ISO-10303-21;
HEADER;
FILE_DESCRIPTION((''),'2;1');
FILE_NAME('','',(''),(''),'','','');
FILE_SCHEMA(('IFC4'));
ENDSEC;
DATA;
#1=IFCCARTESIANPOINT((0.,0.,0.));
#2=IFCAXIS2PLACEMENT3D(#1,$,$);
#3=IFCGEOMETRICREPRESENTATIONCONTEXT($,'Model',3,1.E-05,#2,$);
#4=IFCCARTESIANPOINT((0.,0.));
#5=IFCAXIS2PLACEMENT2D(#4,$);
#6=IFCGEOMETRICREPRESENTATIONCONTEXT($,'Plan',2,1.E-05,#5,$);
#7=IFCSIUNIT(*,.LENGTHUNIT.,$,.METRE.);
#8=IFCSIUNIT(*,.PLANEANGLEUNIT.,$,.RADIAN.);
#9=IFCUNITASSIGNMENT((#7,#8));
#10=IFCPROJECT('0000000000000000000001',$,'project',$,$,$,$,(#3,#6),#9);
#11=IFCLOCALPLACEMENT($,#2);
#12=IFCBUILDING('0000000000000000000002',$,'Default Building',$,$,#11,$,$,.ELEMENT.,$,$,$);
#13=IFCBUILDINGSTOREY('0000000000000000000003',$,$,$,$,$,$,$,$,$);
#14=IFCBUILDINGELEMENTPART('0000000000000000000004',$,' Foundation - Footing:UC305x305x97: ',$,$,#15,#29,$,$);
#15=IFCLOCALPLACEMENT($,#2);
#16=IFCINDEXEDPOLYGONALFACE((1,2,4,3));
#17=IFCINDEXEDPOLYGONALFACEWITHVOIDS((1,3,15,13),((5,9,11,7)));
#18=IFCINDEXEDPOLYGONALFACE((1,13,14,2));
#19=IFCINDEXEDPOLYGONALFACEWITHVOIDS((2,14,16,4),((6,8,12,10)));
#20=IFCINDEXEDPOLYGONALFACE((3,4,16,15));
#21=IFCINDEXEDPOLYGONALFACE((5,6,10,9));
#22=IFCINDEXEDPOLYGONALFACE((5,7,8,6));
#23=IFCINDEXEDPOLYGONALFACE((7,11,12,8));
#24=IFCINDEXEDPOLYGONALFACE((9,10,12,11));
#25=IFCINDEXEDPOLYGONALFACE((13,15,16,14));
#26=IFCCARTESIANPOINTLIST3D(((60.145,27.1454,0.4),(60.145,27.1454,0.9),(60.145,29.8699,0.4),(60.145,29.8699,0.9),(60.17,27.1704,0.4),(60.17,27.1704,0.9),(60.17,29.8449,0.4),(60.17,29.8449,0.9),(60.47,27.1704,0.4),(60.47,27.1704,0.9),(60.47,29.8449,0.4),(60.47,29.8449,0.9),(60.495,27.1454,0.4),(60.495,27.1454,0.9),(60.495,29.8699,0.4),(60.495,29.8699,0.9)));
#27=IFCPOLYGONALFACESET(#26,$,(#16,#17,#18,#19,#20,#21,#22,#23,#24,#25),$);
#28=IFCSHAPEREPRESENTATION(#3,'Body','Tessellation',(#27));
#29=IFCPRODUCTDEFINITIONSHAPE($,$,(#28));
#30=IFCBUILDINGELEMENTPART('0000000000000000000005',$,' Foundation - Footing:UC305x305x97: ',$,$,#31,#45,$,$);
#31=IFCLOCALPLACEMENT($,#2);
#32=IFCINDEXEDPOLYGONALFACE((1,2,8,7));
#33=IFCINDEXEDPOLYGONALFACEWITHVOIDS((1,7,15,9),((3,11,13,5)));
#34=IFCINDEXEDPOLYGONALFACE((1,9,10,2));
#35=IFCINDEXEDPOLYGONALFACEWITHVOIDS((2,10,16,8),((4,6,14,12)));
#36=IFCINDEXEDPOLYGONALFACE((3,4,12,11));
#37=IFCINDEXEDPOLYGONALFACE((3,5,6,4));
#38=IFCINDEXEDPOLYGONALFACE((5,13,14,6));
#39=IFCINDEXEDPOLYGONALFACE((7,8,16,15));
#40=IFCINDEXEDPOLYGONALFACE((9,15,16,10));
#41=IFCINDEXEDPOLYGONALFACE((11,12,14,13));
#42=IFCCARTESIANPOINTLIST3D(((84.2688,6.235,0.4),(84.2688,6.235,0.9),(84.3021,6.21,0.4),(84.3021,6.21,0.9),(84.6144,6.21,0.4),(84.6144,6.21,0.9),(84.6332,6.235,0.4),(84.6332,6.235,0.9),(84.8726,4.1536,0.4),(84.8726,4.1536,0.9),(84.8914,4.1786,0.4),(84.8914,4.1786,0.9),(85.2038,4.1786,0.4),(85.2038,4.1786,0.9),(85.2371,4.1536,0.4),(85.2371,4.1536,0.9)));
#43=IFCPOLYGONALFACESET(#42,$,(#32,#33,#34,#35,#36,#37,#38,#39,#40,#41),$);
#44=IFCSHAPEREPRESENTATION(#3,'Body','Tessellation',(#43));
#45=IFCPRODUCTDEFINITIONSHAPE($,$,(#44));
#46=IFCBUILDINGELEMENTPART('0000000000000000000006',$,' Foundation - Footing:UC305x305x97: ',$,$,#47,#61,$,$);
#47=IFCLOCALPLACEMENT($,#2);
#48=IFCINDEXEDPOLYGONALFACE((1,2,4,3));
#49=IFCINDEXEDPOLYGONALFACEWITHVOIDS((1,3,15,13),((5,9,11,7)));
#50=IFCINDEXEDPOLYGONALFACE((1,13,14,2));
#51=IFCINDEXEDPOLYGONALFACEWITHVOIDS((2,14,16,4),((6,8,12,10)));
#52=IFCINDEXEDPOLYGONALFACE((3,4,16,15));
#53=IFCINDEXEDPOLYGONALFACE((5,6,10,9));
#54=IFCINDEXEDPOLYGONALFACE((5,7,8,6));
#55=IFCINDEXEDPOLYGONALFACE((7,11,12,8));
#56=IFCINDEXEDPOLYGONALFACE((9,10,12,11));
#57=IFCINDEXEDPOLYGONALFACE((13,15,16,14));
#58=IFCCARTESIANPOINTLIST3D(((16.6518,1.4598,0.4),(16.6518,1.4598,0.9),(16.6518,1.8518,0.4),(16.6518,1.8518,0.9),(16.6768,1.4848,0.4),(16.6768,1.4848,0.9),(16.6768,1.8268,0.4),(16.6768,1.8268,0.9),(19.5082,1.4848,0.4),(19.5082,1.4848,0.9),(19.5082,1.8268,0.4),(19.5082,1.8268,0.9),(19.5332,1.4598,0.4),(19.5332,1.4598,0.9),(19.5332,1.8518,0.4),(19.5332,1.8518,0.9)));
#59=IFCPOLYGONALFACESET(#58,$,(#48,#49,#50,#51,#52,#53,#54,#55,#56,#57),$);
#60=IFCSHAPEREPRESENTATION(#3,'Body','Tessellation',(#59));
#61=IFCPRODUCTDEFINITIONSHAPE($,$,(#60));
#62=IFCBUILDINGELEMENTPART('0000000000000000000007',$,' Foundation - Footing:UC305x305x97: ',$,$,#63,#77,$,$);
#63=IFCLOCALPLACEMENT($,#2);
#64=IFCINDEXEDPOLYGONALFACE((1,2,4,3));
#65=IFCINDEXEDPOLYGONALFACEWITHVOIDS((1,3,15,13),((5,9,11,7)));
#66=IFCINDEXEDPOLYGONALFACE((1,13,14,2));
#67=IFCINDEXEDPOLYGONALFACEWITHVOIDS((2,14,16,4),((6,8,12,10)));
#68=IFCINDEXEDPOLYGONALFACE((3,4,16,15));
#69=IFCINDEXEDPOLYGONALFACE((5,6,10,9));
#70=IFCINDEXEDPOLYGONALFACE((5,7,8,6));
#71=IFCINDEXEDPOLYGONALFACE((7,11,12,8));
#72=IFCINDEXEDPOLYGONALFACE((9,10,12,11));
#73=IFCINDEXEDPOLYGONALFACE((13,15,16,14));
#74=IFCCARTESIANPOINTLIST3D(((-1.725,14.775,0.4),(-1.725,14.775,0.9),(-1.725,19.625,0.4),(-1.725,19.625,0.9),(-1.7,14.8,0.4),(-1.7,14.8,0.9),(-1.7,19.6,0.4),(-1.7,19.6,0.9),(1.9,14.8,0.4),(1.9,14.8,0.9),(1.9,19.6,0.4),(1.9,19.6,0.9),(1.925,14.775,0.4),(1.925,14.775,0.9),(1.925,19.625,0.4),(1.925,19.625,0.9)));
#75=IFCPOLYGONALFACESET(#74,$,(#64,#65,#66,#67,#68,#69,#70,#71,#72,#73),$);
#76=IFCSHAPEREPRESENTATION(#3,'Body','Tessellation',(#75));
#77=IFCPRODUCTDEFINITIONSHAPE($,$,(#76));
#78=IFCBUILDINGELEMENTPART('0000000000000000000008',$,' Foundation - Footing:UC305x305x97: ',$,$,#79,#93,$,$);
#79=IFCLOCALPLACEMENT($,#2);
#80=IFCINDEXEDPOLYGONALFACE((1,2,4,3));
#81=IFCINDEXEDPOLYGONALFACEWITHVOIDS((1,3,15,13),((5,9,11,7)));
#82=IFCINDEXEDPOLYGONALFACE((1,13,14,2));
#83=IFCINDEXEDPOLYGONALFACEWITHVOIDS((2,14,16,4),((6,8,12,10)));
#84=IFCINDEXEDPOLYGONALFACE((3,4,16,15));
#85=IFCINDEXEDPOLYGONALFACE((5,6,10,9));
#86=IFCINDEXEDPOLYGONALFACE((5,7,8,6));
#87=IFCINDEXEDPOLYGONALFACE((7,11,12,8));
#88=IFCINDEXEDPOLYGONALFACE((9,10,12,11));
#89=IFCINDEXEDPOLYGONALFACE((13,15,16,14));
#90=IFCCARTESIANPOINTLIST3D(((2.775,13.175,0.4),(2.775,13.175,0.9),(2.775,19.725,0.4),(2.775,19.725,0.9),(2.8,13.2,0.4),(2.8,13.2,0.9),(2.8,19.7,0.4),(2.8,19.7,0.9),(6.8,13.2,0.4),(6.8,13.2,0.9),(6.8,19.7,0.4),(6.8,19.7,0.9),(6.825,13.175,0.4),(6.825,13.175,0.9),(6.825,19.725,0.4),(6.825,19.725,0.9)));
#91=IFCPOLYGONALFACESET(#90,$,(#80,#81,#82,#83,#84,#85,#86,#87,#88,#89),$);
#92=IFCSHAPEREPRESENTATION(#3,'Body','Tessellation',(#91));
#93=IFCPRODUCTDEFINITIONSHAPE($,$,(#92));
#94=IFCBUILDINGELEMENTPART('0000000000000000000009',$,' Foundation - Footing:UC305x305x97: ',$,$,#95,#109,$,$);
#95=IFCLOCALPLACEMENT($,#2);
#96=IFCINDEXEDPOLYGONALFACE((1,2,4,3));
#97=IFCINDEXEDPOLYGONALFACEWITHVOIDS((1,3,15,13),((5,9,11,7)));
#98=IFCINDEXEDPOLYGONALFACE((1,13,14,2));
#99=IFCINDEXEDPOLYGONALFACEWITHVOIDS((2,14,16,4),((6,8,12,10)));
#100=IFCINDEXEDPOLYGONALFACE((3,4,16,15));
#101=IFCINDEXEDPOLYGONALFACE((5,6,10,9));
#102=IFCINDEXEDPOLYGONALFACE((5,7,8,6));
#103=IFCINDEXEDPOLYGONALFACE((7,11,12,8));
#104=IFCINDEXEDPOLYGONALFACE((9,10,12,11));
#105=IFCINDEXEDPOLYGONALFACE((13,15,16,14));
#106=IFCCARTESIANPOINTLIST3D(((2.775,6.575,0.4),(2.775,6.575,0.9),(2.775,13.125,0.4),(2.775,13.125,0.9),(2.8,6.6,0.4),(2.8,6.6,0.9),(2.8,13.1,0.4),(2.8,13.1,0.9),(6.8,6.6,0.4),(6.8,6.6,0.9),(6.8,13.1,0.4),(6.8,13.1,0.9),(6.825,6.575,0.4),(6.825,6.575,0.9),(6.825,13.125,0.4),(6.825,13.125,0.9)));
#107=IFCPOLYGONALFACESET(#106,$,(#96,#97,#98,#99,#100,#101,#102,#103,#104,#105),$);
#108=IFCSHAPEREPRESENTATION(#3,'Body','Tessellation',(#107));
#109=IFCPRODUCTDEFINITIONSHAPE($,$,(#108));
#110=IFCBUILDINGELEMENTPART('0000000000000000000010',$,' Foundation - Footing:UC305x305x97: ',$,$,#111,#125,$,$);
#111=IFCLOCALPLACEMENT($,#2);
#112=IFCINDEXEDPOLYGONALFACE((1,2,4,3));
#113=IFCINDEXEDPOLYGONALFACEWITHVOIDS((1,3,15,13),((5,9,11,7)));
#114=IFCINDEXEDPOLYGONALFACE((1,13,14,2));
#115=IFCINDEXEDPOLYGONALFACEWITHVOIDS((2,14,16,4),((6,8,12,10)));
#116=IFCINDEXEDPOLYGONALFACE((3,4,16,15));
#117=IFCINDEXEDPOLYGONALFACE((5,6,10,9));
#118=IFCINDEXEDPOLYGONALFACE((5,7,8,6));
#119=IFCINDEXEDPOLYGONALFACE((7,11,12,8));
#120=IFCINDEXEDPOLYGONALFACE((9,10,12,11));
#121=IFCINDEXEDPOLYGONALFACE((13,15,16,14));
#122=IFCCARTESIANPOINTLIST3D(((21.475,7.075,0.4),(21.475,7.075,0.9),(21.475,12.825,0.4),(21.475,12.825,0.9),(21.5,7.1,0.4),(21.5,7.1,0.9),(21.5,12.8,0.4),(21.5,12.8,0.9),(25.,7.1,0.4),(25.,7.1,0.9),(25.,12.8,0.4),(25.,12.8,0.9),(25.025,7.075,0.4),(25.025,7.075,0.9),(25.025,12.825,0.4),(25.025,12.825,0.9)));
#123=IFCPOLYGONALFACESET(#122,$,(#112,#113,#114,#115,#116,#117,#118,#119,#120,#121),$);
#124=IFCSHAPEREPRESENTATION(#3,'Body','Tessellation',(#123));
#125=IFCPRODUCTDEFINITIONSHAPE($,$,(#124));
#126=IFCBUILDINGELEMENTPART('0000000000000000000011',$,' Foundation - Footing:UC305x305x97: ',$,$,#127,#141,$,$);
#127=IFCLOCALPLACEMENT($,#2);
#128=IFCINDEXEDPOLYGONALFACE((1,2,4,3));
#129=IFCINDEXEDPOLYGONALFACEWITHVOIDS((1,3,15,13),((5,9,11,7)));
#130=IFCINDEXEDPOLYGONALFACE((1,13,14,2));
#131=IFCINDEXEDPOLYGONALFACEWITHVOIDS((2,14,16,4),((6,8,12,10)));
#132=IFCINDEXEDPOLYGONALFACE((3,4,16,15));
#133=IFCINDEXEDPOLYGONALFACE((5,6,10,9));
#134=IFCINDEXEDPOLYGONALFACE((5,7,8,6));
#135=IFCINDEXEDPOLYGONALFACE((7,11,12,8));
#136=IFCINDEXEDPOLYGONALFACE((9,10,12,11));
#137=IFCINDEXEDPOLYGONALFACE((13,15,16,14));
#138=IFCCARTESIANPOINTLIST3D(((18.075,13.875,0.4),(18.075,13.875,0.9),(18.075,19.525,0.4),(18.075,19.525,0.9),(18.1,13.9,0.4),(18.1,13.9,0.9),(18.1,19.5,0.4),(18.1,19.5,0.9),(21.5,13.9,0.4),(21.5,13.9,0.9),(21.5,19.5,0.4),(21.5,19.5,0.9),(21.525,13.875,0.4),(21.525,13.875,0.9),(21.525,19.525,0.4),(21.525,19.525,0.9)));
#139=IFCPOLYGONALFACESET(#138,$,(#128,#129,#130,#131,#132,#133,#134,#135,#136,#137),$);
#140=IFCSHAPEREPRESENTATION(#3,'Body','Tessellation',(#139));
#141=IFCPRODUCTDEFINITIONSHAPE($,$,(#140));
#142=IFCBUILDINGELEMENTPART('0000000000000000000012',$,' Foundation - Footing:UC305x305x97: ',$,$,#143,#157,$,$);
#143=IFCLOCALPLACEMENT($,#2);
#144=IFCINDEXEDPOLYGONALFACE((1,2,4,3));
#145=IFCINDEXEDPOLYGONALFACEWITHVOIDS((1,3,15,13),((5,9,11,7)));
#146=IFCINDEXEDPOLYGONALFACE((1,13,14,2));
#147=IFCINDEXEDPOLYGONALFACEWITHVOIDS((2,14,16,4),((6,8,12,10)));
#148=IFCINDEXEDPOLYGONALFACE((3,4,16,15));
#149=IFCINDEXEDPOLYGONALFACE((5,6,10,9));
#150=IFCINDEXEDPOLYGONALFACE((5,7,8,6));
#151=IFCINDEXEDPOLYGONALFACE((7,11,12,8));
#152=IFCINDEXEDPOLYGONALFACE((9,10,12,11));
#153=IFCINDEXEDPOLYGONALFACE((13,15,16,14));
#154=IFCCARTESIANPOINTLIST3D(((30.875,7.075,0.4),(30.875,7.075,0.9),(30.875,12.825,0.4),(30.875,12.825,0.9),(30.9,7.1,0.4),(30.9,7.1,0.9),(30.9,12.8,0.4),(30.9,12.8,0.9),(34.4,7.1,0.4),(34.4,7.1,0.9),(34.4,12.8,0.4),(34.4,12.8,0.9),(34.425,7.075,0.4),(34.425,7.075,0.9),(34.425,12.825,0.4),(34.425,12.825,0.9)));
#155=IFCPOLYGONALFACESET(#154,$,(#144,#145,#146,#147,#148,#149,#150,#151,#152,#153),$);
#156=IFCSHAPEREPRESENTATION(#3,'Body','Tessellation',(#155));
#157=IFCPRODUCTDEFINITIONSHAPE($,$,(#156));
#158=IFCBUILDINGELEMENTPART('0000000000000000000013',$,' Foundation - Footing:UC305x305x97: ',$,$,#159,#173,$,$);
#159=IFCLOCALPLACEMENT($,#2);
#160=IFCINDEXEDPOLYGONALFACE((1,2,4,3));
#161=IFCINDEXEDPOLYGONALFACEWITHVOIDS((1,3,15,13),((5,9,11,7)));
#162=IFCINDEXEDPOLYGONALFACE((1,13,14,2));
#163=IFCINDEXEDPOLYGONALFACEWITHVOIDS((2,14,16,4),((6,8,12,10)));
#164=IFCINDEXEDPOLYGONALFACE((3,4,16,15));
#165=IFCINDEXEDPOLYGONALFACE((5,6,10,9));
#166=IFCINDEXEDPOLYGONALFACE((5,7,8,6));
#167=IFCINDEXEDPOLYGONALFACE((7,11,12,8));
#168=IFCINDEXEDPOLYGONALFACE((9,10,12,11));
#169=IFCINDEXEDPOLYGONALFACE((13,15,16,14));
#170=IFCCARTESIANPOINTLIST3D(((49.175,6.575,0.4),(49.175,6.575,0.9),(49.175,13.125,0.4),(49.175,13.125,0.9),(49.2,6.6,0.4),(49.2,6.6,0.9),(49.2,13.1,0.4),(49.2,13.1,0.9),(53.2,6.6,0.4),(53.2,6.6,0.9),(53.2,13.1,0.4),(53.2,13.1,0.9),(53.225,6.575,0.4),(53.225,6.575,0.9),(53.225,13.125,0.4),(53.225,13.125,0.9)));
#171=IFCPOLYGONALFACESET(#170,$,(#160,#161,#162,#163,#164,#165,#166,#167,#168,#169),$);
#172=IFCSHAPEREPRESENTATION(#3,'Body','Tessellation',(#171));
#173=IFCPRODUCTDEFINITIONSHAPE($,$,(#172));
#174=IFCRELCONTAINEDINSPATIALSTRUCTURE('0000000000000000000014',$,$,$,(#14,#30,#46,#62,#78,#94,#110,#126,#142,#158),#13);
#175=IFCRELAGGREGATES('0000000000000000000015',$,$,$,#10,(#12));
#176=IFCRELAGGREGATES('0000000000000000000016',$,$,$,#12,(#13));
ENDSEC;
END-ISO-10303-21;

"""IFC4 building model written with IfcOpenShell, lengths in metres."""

from ifc_helpers import new_model, si_unit, origin, origin_2d, place, context, project, spatial, polyline, outline, extrude, element, save


model = new_model("IFC4")

# Units and contexts
model_context = context("Model", 3, precision=1e-05, world=origin())
plan_context = context("Plan", 2, precision=1e-05, world=origin_2d())
ifc_project = project(units=[si_unit("LENGTHUNIT", "METRE"), si_unit("PLANEANGLEUNIT", "RADIAN")], contexts=[model_context, plan_context])

# Building, storey
building_placement = place(None, origin())
building = spatial("IfcBuilding", under=ifc_project, at=building_placement, Name="Default Building", CompositionType="ELEMENT")
storey = spatial("IfcBuildingStorey", under=building)

# Building element parts, openings
building_element_part_1 = element("IfcBuildingElementPart", 1, inside=storey, Name=" Foundation - Footing:UC305x305x97: ", context=model_context, shape_type="SweptSolid", body=[
    extrude(outline(polyline([(60.495, 27.1454, 0.4), (60.145, 27.1454, 0.4), (60.145, 29.8699, 0.4), (60.495, 29.8699, 0.4), (60.495, 27.1454, 0.4)])), None, (0.0, 0.0, 1.0), 0.5),
])
element("IfcOpeningElement", 2, inside=storey, cuts=building_element_part_1, context=model_context, shape_type="SweptSolid", body=[
    extrude(outline(polyline([(60.47, 27.1704, 0.4), (60.17, 27.1704, 0.4), (60.17, 29.8449, 0.4), (60.47, 29.8449, 0.4), (60.47, 27.1704, 0.4)])), None, (0.0, 0.0, 1.0), 0.5),
])
building_element_part_2 = element("IfcBuildingElementPart", 3, inside=storey, Name=" Foundation - Footing:UC305x305x97: ", context=model_context, shape_type="SweptSolid", body=[
    extrude(outline(polyline([(84.8726, 4.1536, 0.4), (85.2371, 4.1536, 0.4), (84.6332, 6.235, 0.4), (84.2688, 6.235, 0.4), (84.8726, 4.1536, 0.4)])), None, (0.0, 0.0, 1.0), 0.5),
])
element("IfcOpeningElement", 4, inside=storey, cuts=building_element_part_2, context=model_context, shape_type="SweptSolid", body=[
    extrude(outline(polyline([(84.8914, 4.1786, 0.4), (85.2038, 4.1786, 0.4), (84.6144, 6.21, 0.4), (84.3021, 6.21, 0.4), (84.8914, 4.1786, 0.4)])), None, (0.0, 0.0, 1.0), 0.5),
])
building_element_part_3 = element("IfcBuildingElementPart", 5, inside=storey, Name=" Foundation - Footing:UC305x305x97: ", context=model_context, shape_type="SweptSolid", body=[
    extrude(outline(polyline([(16.6518, 1.4598, 0.4), (19.5332, 1.4598, 0.4), (19.5332, 1.8518, 0.4), (16.6518, 1.8518, 0.4), (16.6518, 1.4598, 0.4)])), None, (0.0, 0.0, 1.0), 0.5),
])
element("IfcOpeningElement", 6, inside=storey, cuts=building_element_part_3, context=model_context, shape_type="SweptSolid", body=[
    extrude(outline(polyline([(16.6768, 1.4848, 0.4), (19.5082, 1.4848, 0.4), (19.5082, 1.8268, 0.4), (16.6768, 1.8268, 0.4), (16.6768, 1.4848, 0.4)])), None, (0.0, 0.0, 1.0), 0.5),
])
building_element_part_4 = element("IfcBuildingElementPart", 7, inside=storey, Name=" Foundation - Footing:UC305x305x97: ", context=model_context, shape_type="SweptSolid", body=[
    extrude(outline(polyline([(1.925, 19.625, 0.4), (-1.725, 19.625, 0.4), (-1.725, 14.775, 0.4), (1.925, 14.775, 0.4), (1.925, 19.625, 0.4)])), None, (0.0, 0.0, 1.0), 0.5),
])
element("IfcOpeningElement", 8, inside=storey, cuts=building_element_part_4, context=model_context, shape_type="SweptSolid", body=[
    extrude(outline(polyline([(1.9, 19.6, 0.4), (-1.7, 19.6, 0.4), (-1.7, 14.8, 0.4), (1.9, 14.8, 0.4), (1.9, 19.6, 0.4)])), None, (0.0, 0.0, 1.0), 0.5),
])
building_element_part_5 = element("IfcBuildingElementPart", 9, inside=storey, Name=" Foundation - Footing:UC305x305x97: ", context=model_context, shape_type="SweptSolid", body=[
    extrude(outline(polyline([(6.825, 19.725, 0.4), (2.775, 19.725, 0.4), (2.775, 13.175, 0.4), (6.825, 13.175, 0.4), (6.825, 19.725, 0.4)])), None, (0.0, 0.0, 1.0), 0.5),
])
element("IfcOpeningElement", 10, inside=storey, cuts=building_element_part_5, context=model_context, shape_type="SweptSolid", body=[
    extrude(outline(polyline([(6.8, 19.7, 0.4), (2.8, 19.7, 0.4), (2.8, 13.2, 0.4), (6.8, 13.2, 0.4), (6.8, 19.7, 0.4)])), None, (0.0, 0.0, 1.0), 0.5),
])
building_element_part_6 = element("IfcBuildingElementPart", 11, inside=storey, Name=" Foundation - Footing:UC305x305x97: ", context=model_context, shape_type="SweptSolid", body=[
    extrude(outline(polyline([(6.825, 13.125, 0.4), (2.775, 13.125, 0.4), (2.775, 6.575, 0.4), (6.825, 6.575, 0.4), (6.825, 13.125, 0.4)])), None, (0.0, 0.0, 1.0), 0.5),
])
element("IfcOpeningElement", 12, inside=storey, cuts=building_element_part_6, context=model_context, shape_type="SweptSolid", body=[
    extrude(outline(polyline([(6.8, 13.1, 0.4), (2.8, 13.1, 0.4), (2.8, 6.6, 0.4), (6.8, 6.6, 0.4), (6.8, 13.1, 0.4)])), None, (0.0, 0.0, 1.0), 0.5),
])
building_element_part_7 = element("IfcBuildingElementPart", 13, inside=storey, Name=" Foundation - Footing:UC305x305x97: ", context=model_context, shape_type="SweptSolid", body=[
    extrude(outline(polyline([(25.025, 12.825, 0.4), (21.475, 12.825, 0.4), (21.475, 7.075, 0.4), (25.025, 7.075, 0.4), (25.025, 12.825, 0.4)])), None, (0.0, 0.0, 1.0), 0.5),
])
element("IfcOpeningElement", 14, inside=storey, cuts=building_element_part_7, context=model_context, shape_type="SweptSolid", body=[
    extrude(outline(polyline([(25.0, 12.8, 0.4), (21.5, 12.8, 0.4), (21.5, 7.1, 0.4), (25.0, 7.1, 0.4), (25.0, 12.8, 0.4)])), None, (0.0, 0.0, 1.0), 0.5),
])
building_element_part_8 = element("IfcBuildingElementPart", 15, inside=storey, Name=" Foundation - Footing:UC305x305x97: ", context=model_context, shape_type="SweptSolid", body=[
    extrude(outline(polyline([(21.525, 19.525, 0.4), (18.075, 19.525, 0.4), (18.075, 13.875, 0.4), (21.525, 13.875, 0.4), (21.525, 19.525, 0.4)])), None, (0.0, 0.0, 1.0), 0.5),
])
element("IfcOpeningElement", 16, inside=storey, cuts=building_element_part_8, context=model_context, shape_type="SweptSolid", body=[
    extrude(outline(polyline([(21.5, 19.5, 0.4), (18.1, 19.5, 0.4), (18.1, 13.9, 0.4), (21.5, 13.9, 0.4), (21.5, 19.5, 0.4)])), None, (0.0, 0.0, 1.0), 0.5),
])
building_element_part_9 = element("IfcBuildingElementPart", 17, inside=storey, Name=" Foundation - Footing:UC305x305x97: ", context=model_context, shape_type="SweptSolid", body=[
    extrude(outline(polyline([(34.425, 12.825, 0.4), (30.875, 12.825, 0.4), (30.875, 7.075, 0.4), (34.425, 7.075, 0.4), (34.425, 12.825, 0.4)])), None, (0.0, 0.0, 1.0), 0.5),
])
element("IfcOpeningElement", 18, inside=storey, cuts=building_element_part_9, context=model_context, shape_type="SweptSolid", body=[
    extrude(outline(polyline([(34.4, 12.8, 0.4), (30.9, 12.8, 0.4), (30.9, 7.1, 0.4), (34.4, 7.1, 0.4), (34.4, 12.8, 0.4)])), None, (0.0, 0.0, 1.0), 0.5),
])
building_element_part_10 = element("IfcBuildingElementPart", 19, inside=storey, Name=" Foundation - Footing:UC305x305x97: ", context=model_context, shape_type="SweptSolid", body=[
    extrude(outline(polyline([(53.225, 13.125, 0.4), (49.175, 13.125, 0.4), (49.175, 6.575, 0.4), (53.225, 6.575, 0.4), (53.225, 13.125, 0.4)])), None, (0.0, 0.0, 1.0), 0.5),
])
element("IfcOpeningElement", 20, inside=storey, cuts=building_element_part_10, context=model_context, shape_type="SweptSolid", body=[
    extrude(outline(polyline([(53.2, 13.1, 0.4), (49.2, 13.1, 0.4), (49.2, 6.6, 0.4), (53.2, 6.6, 0.4), (53.2, 13.1, 0.4)])), None, (0.0, 0.0, 1.0), 0.5),
])

save(model, "model.ifc")
